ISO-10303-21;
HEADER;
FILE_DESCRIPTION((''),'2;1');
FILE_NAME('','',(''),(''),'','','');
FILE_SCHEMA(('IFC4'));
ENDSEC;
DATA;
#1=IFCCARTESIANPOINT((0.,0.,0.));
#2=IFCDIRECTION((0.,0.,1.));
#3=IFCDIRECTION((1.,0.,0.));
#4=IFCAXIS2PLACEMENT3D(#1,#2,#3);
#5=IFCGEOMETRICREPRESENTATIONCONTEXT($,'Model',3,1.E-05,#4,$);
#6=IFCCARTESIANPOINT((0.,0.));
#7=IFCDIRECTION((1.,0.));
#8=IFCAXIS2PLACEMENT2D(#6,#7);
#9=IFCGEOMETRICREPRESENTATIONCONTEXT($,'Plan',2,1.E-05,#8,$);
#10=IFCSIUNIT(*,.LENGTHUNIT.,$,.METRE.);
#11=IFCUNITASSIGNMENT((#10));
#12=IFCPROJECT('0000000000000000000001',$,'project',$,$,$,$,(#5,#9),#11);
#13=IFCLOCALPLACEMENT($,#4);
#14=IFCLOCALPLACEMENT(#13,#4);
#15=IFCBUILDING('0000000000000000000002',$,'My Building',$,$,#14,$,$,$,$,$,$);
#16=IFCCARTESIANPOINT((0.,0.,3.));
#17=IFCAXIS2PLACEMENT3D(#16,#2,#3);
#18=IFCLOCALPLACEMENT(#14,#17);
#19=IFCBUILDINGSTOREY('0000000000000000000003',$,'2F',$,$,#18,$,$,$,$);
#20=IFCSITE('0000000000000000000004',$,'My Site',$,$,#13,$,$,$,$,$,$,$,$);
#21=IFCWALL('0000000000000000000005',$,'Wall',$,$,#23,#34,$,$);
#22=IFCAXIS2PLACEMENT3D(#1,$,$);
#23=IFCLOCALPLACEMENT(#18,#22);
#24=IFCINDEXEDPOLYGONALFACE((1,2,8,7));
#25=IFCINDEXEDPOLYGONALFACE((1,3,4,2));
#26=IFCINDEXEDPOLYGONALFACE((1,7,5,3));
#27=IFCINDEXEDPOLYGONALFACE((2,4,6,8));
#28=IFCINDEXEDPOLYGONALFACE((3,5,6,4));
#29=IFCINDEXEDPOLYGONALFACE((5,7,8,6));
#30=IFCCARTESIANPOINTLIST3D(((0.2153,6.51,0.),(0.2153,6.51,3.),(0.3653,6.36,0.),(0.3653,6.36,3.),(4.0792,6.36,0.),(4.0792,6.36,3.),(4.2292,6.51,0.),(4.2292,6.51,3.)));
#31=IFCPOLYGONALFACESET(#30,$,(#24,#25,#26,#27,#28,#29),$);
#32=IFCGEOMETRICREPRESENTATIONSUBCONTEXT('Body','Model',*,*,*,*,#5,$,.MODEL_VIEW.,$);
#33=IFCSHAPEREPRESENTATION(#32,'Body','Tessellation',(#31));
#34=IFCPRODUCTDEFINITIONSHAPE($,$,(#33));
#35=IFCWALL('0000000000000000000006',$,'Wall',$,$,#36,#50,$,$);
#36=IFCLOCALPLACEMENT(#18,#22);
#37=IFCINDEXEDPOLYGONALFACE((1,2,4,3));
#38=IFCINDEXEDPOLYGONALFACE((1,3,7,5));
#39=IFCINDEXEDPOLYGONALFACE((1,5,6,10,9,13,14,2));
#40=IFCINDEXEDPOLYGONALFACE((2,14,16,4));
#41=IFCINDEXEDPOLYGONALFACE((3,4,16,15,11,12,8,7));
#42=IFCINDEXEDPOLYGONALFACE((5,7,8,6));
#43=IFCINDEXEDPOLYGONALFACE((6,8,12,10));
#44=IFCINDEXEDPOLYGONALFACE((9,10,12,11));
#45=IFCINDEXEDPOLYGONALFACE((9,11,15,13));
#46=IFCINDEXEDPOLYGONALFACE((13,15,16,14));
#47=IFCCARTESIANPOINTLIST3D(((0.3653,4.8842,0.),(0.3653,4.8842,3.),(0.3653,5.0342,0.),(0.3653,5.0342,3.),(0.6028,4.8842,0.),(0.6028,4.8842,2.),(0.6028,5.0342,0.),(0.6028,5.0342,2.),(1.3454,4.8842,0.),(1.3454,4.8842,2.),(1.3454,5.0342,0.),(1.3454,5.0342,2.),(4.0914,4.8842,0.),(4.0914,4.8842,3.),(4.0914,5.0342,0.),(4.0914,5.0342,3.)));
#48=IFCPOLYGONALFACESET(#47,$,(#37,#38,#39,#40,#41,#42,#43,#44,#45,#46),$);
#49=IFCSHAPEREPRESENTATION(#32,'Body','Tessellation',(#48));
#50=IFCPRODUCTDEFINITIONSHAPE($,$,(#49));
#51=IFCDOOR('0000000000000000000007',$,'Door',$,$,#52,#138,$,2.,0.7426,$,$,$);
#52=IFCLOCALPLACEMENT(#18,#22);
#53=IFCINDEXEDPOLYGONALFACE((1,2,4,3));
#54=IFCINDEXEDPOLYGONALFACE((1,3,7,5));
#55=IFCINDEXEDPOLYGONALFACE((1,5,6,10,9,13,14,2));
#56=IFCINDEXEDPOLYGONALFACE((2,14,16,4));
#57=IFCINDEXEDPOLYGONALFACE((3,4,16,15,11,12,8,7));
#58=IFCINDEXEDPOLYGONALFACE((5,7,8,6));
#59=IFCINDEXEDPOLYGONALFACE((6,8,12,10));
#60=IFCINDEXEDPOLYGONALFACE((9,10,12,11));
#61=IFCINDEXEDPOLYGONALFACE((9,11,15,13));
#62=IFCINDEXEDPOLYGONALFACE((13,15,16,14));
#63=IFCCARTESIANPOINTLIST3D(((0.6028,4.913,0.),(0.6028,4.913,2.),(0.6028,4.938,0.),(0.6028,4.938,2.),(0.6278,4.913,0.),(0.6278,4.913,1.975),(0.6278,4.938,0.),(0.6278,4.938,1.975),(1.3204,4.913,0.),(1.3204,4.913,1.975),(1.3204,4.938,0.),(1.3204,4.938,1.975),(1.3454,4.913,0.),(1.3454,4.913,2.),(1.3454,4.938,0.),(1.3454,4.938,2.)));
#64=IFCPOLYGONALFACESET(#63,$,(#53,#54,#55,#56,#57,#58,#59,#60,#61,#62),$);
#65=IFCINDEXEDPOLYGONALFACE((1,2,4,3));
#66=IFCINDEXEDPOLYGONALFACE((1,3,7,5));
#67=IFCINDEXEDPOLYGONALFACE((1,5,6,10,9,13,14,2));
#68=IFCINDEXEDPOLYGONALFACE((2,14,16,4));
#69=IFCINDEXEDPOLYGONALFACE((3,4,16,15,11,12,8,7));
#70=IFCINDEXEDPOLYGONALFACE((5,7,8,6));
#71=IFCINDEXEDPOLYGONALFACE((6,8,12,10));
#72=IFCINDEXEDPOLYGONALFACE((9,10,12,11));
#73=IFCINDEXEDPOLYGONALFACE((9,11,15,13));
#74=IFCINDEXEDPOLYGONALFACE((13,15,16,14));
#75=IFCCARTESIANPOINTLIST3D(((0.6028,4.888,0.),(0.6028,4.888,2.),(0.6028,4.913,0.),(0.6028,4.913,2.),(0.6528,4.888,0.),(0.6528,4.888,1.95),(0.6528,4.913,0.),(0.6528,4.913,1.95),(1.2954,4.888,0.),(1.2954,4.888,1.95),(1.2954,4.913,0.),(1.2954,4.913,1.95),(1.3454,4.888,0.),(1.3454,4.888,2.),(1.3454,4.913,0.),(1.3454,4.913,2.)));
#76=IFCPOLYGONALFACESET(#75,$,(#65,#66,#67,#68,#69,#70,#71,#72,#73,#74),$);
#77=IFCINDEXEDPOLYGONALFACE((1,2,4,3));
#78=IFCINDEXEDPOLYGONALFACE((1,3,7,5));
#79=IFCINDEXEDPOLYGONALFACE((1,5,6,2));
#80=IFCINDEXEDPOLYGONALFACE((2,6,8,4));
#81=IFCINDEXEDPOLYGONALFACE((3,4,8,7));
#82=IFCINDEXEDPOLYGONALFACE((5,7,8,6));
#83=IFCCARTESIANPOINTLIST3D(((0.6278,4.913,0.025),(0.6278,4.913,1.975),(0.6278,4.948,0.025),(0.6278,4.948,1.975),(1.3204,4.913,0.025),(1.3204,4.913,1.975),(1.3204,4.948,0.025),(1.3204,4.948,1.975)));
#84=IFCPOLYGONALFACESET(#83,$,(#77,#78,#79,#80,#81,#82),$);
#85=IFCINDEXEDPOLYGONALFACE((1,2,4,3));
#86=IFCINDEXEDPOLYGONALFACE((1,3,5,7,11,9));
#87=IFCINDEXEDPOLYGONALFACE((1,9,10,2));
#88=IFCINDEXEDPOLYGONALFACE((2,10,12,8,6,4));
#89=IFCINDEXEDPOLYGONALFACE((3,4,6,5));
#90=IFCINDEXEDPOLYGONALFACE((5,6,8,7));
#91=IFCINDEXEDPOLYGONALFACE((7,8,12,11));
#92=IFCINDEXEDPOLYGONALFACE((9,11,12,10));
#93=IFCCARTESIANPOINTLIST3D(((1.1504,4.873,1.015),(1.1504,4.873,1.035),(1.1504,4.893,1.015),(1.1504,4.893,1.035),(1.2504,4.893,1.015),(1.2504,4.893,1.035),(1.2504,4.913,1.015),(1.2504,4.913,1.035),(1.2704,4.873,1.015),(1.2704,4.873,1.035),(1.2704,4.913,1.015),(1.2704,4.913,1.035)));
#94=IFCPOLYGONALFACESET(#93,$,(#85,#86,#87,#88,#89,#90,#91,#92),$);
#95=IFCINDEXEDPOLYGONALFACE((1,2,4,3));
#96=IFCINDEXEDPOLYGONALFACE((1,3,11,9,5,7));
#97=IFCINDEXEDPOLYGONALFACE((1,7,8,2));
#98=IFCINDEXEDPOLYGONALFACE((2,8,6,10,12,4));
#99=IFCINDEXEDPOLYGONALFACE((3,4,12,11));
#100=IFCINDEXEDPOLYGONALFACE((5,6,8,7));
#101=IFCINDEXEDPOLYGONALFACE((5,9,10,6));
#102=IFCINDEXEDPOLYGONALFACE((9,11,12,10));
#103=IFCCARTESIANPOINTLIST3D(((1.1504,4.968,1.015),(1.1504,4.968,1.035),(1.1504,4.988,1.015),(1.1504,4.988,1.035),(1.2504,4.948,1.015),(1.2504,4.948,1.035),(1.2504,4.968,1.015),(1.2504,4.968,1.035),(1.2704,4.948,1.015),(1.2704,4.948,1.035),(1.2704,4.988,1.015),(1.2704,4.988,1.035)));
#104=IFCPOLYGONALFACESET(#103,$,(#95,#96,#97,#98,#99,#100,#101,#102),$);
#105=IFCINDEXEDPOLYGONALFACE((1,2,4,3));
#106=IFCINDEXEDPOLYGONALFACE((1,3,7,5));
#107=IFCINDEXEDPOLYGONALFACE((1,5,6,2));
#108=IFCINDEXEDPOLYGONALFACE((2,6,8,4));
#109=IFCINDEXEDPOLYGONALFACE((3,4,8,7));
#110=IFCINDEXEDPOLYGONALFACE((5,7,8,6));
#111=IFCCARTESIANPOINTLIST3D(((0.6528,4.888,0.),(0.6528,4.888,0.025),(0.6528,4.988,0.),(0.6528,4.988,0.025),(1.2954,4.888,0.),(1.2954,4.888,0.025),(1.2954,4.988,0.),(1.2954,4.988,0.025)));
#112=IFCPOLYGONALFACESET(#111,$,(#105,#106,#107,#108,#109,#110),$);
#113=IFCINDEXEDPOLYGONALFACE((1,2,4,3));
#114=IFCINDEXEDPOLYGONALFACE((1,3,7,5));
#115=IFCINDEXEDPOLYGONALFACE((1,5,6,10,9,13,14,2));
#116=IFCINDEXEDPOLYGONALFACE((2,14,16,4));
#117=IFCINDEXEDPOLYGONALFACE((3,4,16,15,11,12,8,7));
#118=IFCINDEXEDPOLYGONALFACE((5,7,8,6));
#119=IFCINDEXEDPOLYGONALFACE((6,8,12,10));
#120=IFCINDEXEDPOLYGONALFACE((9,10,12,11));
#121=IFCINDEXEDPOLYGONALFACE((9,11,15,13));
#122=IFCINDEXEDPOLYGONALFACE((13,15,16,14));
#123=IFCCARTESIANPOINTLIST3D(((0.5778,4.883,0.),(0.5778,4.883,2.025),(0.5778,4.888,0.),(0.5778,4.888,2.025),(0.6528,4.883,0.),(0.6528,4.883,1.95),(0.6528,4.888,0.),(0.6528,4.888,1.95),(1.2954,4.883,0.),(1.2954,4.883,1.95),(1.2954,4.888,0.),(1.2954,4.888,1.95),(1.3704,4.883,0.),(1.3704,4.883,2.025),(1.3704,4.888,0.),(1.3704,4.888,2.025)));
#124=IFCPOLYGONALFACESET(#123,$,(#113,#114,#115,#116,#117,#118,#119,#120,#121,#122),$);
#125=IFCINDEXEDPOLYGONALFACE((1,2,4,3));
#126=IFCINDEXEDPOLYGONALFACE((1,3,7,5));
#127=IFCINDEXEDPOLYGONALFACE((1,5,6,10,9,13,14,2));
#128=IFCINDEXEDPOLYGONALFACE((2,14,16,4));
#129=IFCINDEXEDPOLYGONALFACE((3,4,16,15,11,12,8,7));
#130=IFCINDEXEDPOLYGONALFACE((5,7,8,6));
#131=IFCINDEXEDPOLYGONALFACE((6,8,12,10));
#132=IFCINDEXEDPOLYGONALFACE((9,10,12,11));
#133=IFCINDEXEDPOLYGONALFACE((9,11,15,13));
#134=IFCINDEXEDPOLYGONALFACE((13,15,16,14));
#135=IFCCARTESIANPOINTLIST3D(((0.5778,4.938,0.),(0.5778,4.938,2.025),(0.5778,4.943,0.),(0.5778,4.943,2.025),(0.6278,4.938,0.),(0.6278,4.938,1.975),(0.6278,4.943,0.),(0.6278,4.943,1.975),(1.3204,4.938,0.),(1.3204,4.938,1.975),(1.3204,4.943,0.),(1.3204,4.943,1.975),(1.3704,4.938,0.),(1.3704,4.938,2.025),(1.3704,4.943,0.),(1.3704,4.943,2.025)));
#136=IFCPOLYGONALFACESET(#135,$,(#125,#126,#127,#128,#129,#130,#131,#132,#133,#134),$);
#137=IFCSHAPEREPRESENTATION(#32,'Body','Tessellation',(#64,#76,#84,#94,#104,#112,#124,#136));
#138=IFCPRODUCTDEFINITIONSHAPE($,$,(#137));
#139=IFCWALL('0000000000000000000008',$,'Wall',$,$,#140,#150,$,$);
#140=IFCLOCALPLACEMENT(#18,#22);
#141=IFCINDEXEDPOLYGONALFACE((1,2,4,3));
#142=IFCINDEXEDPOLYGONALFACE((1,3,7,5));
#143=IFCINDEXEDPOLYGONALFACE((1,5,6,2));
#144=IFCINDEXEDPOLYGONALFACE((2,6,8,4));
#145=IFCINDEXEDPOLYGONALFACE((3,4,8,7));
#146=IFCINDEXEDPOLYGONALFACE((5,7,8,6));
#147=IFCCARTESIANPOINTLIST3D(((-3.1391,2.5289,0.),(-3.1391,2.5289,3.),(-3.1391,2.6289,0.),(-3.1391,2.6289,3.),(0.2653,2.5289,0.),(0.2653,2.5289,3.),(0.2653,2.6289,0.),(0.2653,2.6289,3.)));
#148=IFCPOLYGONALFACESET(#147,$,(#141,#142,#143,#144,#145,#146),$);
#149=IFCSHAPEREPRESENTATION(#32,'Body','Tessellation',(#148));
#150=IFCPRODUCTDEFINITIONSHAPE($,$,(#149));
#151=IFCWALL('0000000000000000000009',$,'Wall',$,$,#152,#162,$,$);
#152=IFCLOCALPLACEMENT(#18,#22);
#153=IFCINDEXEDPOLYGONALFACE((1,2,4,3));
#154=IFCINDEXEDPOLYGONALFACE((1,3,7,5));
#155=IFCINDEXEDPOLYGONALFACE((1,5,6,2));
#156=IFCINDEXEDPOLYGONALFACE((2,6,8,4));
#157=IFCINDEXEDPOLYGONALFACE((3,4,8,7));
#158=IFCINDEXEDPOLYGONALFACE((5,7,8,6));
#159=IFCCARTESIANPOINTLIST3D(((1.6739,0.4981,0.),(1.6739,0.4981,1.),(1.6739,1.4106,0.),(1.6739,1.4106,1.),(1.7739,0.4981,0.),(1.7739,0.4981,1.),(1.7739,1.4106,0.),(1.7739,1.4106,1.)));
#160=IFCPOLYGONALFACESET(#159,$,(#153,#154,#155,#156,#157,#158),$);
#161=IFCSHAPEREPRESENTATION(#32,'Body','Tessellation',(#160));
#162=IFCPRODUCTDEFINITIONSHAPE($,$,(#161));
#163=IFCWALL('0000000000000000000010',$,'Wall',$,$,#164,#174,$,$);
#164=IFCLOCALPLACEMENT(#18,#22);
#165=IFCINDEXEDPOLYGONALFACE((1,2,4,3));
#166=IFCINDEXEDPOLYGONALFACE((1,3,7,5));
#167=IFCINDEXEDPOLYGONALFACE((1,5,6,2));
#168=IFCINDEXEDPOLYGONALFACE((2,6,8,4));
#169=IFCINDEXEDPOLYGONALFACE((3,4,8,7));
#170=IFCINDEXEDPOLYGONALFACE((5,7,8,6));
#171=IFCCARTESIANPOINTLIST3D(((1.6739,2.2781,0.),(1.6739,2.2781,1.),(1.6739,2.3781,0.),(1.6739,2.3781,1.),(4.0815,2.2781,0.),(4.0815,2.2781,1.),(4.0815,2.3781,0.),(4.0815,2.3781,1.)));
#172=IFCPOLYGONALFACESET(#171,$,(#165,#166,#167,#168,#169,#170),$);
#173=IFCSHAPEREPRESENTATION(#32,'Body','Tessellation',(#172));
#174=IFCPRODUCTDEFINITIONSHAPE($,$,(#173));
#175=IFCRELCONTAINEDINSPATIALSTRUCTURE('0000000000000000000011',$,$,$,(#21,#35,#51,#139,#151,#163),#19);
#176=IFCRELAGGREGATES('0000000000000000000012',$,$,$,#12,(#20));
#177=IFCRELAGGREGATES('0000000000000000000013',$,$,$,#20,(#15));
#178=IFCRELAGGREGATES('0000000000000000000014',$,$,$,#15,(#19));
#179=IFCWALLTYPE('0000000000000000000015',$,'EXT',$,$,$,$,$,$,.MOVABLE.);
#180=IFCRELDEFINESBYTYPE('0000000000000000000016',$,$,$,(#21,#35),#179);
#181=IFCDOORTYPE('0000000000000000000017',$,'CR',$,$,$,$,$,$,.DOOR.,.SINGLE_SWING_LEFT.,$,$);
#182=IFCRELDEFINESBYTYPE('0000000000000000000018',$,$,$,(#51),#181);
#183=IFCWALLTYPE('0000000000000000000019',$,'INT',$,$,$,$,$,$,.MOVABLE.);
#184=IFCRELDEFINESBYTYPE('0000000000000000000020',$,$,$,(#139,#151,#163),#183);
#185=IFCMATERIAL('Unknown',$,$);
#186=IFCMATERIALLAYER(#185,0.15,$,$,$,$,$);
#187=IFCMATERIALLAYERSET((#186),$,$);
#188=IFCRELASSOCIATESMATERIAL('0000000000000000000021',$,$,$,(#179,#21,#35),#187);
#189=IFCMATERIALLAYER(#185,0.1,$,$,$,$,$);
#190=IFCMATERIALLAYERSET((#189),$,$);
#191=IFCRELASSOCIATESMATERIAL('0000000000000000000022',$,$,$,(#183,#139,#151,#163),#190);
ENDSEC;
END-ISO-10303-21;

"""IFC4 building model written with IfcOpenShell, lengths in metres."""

from ifc_helpers import new_model, entity, si_unit, frame, origin_with_axes, origin_2d_with_axis, place, context, subcontext, project, spatial, line, indexed_curve, outline, extrude, shape, source, transform, mapped, material, layer, layer_set, layer_usage, type_object, type_shapes, element, fill, save


model = new_model("IFC4")

# Units and contexts
model_context = context("Model", 3, precision=1e-05, world=origin_with_axes())
plan_context = context("Plan", 2, precision=1e-05, world=origin_2d_with_axis())
body_context_1 = subcontext(model_context, "Body", "Model", "MODEL_VIEW")
body_context_2 = subcontext(plan_context, "Body", "Plan", "PLAN_VIEW")
ifc_project = project(units=[si_unit("LENGTHUNIT", "METRE")], contexts=[model_context, plan_context])

# Site, building, storey
site_placement = place(None, origin_with_axes())
site = spatial("IfcSite", under=ifc_project, at=site_placement, Name="My Site")
building_placement = place(site_placement, origin_with_axes())
building = spatial("IfcBuilding", under=site, at=building_placement, Name="My Building")
storey_placement = place(building_placement, frame((0.0, 0.0, 3.0), z_axis=(0.0, 0.0, 1.0), x_axis=(1.0, 0.0, 0.0)))
storey = spatial("IfcBuildingStorey", under=building, at=storey_placement, Name="2F")

# Shared definitions
ifc_material = material(Name="Unknown")

# Shared definitions
ifc_layer_1 = layer(ifc_material, 0.15)
ifc_layer_set_1 = layer_set([ifc_layer_1])
wall_type_1 = type_object("IfcWallType", Name="EXT", PredefinedType="MOVABLE", material=ifc_layer_set_1)

# Wall
ifc_layer_usage_1 = layer_usage(ifc_layer_set_1, "AXIS2", "POSITIVE", -0.15)
wall_1_placement = place(storey_placement, frame((0.2153, 6.51, 0.0), z_axis=(0.0, 0.0, 1.0), x_axis=(1.0, 0.0, 0.0)))
element("IfcWall", 1, at=wall_1_placement, inside=storey, type_object=wall_type_1, material=ifc_layer_usage_1, Name="Wall", context=body_context_1, shape_type="SweptSolid", body=[
    extrude(outline(indexed_curve([(0.15, -0.15), (0.0, 0.0), (4.0139, 0.0), (3.8639, -0.15)], segments=[line(1, 2, 3, 4, 1)])), origin_with_axes(), (0.0, 0.0, 1.0), 3.0),
])

# Wall, opening, door
ifc_layer_usage_2 = layer_usage(ifc_layer_set_1, "AXIS2", "POSITIVE", -0.15)
wall_2_placement = place(storey_placement, frame((4.0914, 4.8842, 0.0), z_axis=(0.0, 0.0, 1.0), x_axis=(-1.0, 0.0, 0.0)))
wall_2 = element("IfcWall", 2, at=wall_2_placement, inside=storey, type_object=wall_type_1, material=ifc_layer_usage_2, Name="Wall", context=body_context_1, shape_type="SweptSolid", body=[
    extrude(outline(indexed_curve([(0.0, -0.15), (0.0, 0.0), (3.7261, 0.0), (3.7261, -0.15)], segments=[line(1, 2, 3, 4, 1)])), origin_with_axes(), (0.0, 0.0, 1.0), 3.0),
])
placement_1 = place(storey_placement, frame((0.6028, 4.888, 0.0), z_axis=(0.0, 0.0, 1.0), x_axis=(1.0, 0.0, 0.0)))
opening_1 = element("IfcOpeningElement", 3, at=placement_1, cuts=wall_2, PredefinedType="OPENING", context=body_context_1, shape_type="SweptSolid", body=[
    extrude(outline(indexed_curve([(0.0, 0.0), (0.7426, 0.0), (0.7426, 2.0), (0.0, 2.0)], segments=[line(1, 2, 3, 4, 1)])), frame((0.0, -0.6, 0.0), z_axis=(0.0, -1.0, 0.0), x_axis=(1.0, 0.0, 0.0)), (0.0, 0.0, -1.0), 1.2),
])
door_type_1 = type_object("IfcDoorType", Name="CR", OperationType="SINGLE_SWING_LEFT", PredefinedType="DOOR")
shared_shape_1 = source(origin_with_axes(), body_context_1, "Body", "SweptSolid", [
    extrude(outline(indexed_curve([(0.0, 0.0), (0.0, 2.0), (0.7426, 2.0), (0.7426, 0.0), (0.7176, 0.0), (0.7176, 1.975), (0.025, 1.975), (0.025, 0.0)], segments=[line(1, 2, 3, 4, 5, 6, 7, 8, 1)])), frame((0.0, 0.025, 0.0), z_axis=(0.0, -1.0, 0.0), x_axis=(1.0, 0.0, 0.0)), (0.0, 0.0, -1.0), 0.025),
    extrude(outline(indexed_curve([(0.0, 0.0), (0.0, 2.0), (0.7426, 2.0), (0.7426, 0.0), (0.6926, 0.0), (0.6926, 1.95), (0.05, 1.95), (0.05, 0.0)], segments=[line(1, 2, 3, 4, 5, 6, 7, 8, 1)])), frame((0.0, 0.0, 0.0), z_axis=(0.0, -1.0, 0.0), x_axis=(1.0, 0.0, 0.0)), (0.0, 0.0, -1.0), 0.025),
    extrude(outline(indexed_curve([(0.0, 0.0), (0.6926, 0.0), (0.6926, 0.035), (0.0, 0.035)], segments=[line(1, 2, 3, 4, 1)])), frame((0.025, 0.025, 0.025), z_axis=(0.0, 0.0, 1.0), x_axis=(1.0, 0.0, 0.0)), (0.0, 0.0, 1.0), 1.95),
    extrude(outline(indexed_curve([(0.0, 0.0), (0.0, -0.04), (-0.12, -0.04), (-0.12, -0.02), (-0.02, -0.02), (-0.02, 0.0)], segments=[line(1, 2, 3, 4, 5, 6, 1)])), frame((0.6676, 0.025, 1.015), z_axis=(0.0, 0.0, 1.0), x_axis=(1.0, 0.0, 0.0)), (0.0, 0.0, 1.0), 0.02),
    extrude(outline(indexed_curve([(0.0, 0.0), (0.0, 0.04), (-0.12, 0.04), (-0.12, 0.02), (-0.02, 0.02), (-0.02, 0.0)], segments=[line(1, 2, 3, 4, 5, 6, 1)])), frame((0.6676, 0.06, 1.015), z_axis=(0.0, 0.0, 1.0), x_axis=(1.0, 0.0, 0.0)), (0.0, 0.0, 1.0), 0.02),
    extrude(outline(indexed_curve([(0.0, 0.0), (0.6426, 0.0), (0.6426, 0.1), (0.0, 0.1)], segments=[line(1, 2, 3, 4, 1)])), frame((0.05, 0.0, 0.0), z_axis=(0.0, 0.0, 1.0), x_axis=(1.0, 0.0, 0.0)), (0.0, 0.0, 1.0), 0.025),
    extrude(outline(indexed_curve([(0.0, 0.0), (0.0, 2.025), (0.7926, 2.025), (0.7926, 0.0), (0.7176, 0.0), (0.7176, 1.95), (0.075, 1.95), (0.075, 0.0)], segments=[line(1, 2, 3, 4, 5, 6, 7, 8, 1)])), frame((-0.025, -0.005, 0.0), z_axis=(0.0, -1.0, 0.0), x_axis=(1.0, 0.0, 0.0)), (0.0, 0.0, -1.0), 0.005),
    extrude(outline(indexed_curve([(0.0, 0.0), (0.0, 2.025), (0.7926, 2.025), (0.7926, 0.0), (0.7426, 0.0), (0.7426, 1.975), (0.05, 1.975), (0.05, 0.0)], segments=[line(1, 2, 3, 4, 5, 6, 7, 8, 1)])), frame((-0.025, 0.05, 0.0), z_axis=(0.0, -1.0, 0.0), x_axis=(1.0, 0.0, 0.0)), (0.0, 0.0, -1.0), 0.005),
])
shared_shape_2 = source(origin_with_axes(), body_context_2, "Body", "Curve2D", [
    entity("IfcIndexedPolyCurve", entity("IfcCartesianPointList2D", [[0.0, 0.0], [0.0, 0.05], [0.025, 0.05], [0.025, 0.025], [0.05, 0.025], [0.05, 0.0]]), [entity("IfcLineIndex", [1, 2, 3, 4, 5, 6, 1])]),
    entity("IfcIndexedPolyCurve", entity("IfcCartesianPointList2D", [[0.7426, 0.0], [0.7426, 0.05], [0.7176, 0.05], [0.7176, 0.025], [0.6926, 0.025], [0.6926, 0.0]]), [entity("IfcLineIndex", [1, 2, 3, 4, 5, 6, 1])]),
    entity("IfcTrimmedCurve", entity("IfcEllipse", entity("IfcAxis2Placement2D", entity("IfcCartesianPoint", [0.06, 0.05]), entity("IfcDirection", [1.0, 0.0])), 0.6576, 0.6926), [entity("IfcCartesianPoint", [0.7176, 0.05])], [entity("IfcCartesianPoint", [0.06, 0.7426])], True, "CARTESIAN"),
    entity("IfcIndexedPolyCurve", entity("IfcCartesianPointList2D", [[0.025, 0.05], [0.06, 0.05], [0.06, 0.7426], [0.025, 0.7426]]), [entity("IfcLineIndex", [1, 2, 3, 4, 1])]),
])
type_shapes(door_type_1, [shared_shape_1, shared_shape_2])
door_1 = element("IfcDoor", 4, at=placement_1, inside=storey, type_object=door_type_1, Name="Door", OverallHeight=2.0, OverallWidth=0.7426, shapes=[
    shape(body_context_1, "Body", "MappedRepresentation", [mapped(shared_shape_1, transform((0.0, 0.0, 0.0), x_axis=(1.0, 0.0, 0.0), y_axis=(0.0, 1.0, 0.0), z_axis=(0.0, 0.0, 1.0), scale=1.0))]),
    shape(body_context_2, "Body", "MappedRepresentation", [mapped(shared_shape_2, transform((0.0, 0.0, 0.0), x_axis=(1.0, 0.0, 0.0), y_axis=(0.0, 1.0, 0.0), z_axis=(0.0, 0.0, 1.0), scale=1.0))]),
])
fill(opening_1, door_1)

# Shared definitions
ifc_layer_2 = layer(ifc_material, 0.1)
ifc_layer_set_2 = layer_set([ifc_layer_2])
wall_type_2 = type_object("IfcWallType", Name="INT", PredefinedType="MOVABLE", material=ifc_layer_set_2)

# Walls
ifc_layer_usage_3 = layer_usage(ifc_layer_set_2, "AXIS2", "POSITIVE", -0.1)
wall_3_placement = place(storey_placement, frame((-3.1391, 2.6289, 0.0), z_axis=(0.0, 0.0, 1.0), x_axis=(1.0, 0.0, 0.0)))
element("IfcWall", 5, at=wall_3_placement, inside=storey, type_object=wall_type_2, material=ifc_layer_usage_3, Name="Wall", context=body_context_1, shape_type="SweptSolid", body=[
    extrude(outline(indexed_curve([(0.0, -0.1), (0.0, 0.0), (3.4045, 0.0), (3.4045, -0.1)], segments=[line(1, 2, 3, 4, 1)])), origin_with_axes(), (0.0, 0.0, 1.0), 3.0),
])
ifc_layer_usage_4 = layer_usage(ifc_layer_set_2, "AXIS2", "POSITIVE", 0.0)
wall_4_placement = place(storey_placement, frame((1.6739, 1.4106, 0.0), z_axis=(0.0, 0.0, 1.0), x_axis=(0.0, -1.0, 0.0)))
element("IfcWall", 6, at=wall_4_placement, inside=storey, type_object=wall_type_2, material=ifc_layer_usage_4, Name="Wall", context=body_context_1, shape_type="SweptSolid", body=[
    extrude(outline(indexed_curve([(0.0, 0.0), (0.0, 0.1), (0.9125, 0.1), (0.9125, 0.0)], segments=[line(1, 2, 3, 4, 1)])), origin_with_axes(), (0.0, 0.0, 1.0), 1.0),
])
ifc_layer_usage_5 = layer_usage(ifc_layer_set_2, "AXIS2", "POSITIVE", 0.0)
wall_5_placement = place(storey_placement, frame((1.6739, 2.2781, 0.0), z_axis=(0.0, 0.0, 1.0), x_axis=(1.0, 0.0, 0.0)))
element("IfcWall", 7, at=wall_5_placement, inside=storey, type_object=wall_type_2, material=ifc_layer_usage_5, Name="Wall", context=body_context_1, shape_type="SweptSolid", body=[
    extrude(outline(indexed_curve([(0.0, 0.0), (0.0, 0.1), (2.4075, 0.1), (2.4075, 0.0)], segments=[line(1, 2, 3, 4, 1)])), origin_with_axes(), (0.0, 0.0, 1.0), 1.0),
])

save(model, "model.ifc")
